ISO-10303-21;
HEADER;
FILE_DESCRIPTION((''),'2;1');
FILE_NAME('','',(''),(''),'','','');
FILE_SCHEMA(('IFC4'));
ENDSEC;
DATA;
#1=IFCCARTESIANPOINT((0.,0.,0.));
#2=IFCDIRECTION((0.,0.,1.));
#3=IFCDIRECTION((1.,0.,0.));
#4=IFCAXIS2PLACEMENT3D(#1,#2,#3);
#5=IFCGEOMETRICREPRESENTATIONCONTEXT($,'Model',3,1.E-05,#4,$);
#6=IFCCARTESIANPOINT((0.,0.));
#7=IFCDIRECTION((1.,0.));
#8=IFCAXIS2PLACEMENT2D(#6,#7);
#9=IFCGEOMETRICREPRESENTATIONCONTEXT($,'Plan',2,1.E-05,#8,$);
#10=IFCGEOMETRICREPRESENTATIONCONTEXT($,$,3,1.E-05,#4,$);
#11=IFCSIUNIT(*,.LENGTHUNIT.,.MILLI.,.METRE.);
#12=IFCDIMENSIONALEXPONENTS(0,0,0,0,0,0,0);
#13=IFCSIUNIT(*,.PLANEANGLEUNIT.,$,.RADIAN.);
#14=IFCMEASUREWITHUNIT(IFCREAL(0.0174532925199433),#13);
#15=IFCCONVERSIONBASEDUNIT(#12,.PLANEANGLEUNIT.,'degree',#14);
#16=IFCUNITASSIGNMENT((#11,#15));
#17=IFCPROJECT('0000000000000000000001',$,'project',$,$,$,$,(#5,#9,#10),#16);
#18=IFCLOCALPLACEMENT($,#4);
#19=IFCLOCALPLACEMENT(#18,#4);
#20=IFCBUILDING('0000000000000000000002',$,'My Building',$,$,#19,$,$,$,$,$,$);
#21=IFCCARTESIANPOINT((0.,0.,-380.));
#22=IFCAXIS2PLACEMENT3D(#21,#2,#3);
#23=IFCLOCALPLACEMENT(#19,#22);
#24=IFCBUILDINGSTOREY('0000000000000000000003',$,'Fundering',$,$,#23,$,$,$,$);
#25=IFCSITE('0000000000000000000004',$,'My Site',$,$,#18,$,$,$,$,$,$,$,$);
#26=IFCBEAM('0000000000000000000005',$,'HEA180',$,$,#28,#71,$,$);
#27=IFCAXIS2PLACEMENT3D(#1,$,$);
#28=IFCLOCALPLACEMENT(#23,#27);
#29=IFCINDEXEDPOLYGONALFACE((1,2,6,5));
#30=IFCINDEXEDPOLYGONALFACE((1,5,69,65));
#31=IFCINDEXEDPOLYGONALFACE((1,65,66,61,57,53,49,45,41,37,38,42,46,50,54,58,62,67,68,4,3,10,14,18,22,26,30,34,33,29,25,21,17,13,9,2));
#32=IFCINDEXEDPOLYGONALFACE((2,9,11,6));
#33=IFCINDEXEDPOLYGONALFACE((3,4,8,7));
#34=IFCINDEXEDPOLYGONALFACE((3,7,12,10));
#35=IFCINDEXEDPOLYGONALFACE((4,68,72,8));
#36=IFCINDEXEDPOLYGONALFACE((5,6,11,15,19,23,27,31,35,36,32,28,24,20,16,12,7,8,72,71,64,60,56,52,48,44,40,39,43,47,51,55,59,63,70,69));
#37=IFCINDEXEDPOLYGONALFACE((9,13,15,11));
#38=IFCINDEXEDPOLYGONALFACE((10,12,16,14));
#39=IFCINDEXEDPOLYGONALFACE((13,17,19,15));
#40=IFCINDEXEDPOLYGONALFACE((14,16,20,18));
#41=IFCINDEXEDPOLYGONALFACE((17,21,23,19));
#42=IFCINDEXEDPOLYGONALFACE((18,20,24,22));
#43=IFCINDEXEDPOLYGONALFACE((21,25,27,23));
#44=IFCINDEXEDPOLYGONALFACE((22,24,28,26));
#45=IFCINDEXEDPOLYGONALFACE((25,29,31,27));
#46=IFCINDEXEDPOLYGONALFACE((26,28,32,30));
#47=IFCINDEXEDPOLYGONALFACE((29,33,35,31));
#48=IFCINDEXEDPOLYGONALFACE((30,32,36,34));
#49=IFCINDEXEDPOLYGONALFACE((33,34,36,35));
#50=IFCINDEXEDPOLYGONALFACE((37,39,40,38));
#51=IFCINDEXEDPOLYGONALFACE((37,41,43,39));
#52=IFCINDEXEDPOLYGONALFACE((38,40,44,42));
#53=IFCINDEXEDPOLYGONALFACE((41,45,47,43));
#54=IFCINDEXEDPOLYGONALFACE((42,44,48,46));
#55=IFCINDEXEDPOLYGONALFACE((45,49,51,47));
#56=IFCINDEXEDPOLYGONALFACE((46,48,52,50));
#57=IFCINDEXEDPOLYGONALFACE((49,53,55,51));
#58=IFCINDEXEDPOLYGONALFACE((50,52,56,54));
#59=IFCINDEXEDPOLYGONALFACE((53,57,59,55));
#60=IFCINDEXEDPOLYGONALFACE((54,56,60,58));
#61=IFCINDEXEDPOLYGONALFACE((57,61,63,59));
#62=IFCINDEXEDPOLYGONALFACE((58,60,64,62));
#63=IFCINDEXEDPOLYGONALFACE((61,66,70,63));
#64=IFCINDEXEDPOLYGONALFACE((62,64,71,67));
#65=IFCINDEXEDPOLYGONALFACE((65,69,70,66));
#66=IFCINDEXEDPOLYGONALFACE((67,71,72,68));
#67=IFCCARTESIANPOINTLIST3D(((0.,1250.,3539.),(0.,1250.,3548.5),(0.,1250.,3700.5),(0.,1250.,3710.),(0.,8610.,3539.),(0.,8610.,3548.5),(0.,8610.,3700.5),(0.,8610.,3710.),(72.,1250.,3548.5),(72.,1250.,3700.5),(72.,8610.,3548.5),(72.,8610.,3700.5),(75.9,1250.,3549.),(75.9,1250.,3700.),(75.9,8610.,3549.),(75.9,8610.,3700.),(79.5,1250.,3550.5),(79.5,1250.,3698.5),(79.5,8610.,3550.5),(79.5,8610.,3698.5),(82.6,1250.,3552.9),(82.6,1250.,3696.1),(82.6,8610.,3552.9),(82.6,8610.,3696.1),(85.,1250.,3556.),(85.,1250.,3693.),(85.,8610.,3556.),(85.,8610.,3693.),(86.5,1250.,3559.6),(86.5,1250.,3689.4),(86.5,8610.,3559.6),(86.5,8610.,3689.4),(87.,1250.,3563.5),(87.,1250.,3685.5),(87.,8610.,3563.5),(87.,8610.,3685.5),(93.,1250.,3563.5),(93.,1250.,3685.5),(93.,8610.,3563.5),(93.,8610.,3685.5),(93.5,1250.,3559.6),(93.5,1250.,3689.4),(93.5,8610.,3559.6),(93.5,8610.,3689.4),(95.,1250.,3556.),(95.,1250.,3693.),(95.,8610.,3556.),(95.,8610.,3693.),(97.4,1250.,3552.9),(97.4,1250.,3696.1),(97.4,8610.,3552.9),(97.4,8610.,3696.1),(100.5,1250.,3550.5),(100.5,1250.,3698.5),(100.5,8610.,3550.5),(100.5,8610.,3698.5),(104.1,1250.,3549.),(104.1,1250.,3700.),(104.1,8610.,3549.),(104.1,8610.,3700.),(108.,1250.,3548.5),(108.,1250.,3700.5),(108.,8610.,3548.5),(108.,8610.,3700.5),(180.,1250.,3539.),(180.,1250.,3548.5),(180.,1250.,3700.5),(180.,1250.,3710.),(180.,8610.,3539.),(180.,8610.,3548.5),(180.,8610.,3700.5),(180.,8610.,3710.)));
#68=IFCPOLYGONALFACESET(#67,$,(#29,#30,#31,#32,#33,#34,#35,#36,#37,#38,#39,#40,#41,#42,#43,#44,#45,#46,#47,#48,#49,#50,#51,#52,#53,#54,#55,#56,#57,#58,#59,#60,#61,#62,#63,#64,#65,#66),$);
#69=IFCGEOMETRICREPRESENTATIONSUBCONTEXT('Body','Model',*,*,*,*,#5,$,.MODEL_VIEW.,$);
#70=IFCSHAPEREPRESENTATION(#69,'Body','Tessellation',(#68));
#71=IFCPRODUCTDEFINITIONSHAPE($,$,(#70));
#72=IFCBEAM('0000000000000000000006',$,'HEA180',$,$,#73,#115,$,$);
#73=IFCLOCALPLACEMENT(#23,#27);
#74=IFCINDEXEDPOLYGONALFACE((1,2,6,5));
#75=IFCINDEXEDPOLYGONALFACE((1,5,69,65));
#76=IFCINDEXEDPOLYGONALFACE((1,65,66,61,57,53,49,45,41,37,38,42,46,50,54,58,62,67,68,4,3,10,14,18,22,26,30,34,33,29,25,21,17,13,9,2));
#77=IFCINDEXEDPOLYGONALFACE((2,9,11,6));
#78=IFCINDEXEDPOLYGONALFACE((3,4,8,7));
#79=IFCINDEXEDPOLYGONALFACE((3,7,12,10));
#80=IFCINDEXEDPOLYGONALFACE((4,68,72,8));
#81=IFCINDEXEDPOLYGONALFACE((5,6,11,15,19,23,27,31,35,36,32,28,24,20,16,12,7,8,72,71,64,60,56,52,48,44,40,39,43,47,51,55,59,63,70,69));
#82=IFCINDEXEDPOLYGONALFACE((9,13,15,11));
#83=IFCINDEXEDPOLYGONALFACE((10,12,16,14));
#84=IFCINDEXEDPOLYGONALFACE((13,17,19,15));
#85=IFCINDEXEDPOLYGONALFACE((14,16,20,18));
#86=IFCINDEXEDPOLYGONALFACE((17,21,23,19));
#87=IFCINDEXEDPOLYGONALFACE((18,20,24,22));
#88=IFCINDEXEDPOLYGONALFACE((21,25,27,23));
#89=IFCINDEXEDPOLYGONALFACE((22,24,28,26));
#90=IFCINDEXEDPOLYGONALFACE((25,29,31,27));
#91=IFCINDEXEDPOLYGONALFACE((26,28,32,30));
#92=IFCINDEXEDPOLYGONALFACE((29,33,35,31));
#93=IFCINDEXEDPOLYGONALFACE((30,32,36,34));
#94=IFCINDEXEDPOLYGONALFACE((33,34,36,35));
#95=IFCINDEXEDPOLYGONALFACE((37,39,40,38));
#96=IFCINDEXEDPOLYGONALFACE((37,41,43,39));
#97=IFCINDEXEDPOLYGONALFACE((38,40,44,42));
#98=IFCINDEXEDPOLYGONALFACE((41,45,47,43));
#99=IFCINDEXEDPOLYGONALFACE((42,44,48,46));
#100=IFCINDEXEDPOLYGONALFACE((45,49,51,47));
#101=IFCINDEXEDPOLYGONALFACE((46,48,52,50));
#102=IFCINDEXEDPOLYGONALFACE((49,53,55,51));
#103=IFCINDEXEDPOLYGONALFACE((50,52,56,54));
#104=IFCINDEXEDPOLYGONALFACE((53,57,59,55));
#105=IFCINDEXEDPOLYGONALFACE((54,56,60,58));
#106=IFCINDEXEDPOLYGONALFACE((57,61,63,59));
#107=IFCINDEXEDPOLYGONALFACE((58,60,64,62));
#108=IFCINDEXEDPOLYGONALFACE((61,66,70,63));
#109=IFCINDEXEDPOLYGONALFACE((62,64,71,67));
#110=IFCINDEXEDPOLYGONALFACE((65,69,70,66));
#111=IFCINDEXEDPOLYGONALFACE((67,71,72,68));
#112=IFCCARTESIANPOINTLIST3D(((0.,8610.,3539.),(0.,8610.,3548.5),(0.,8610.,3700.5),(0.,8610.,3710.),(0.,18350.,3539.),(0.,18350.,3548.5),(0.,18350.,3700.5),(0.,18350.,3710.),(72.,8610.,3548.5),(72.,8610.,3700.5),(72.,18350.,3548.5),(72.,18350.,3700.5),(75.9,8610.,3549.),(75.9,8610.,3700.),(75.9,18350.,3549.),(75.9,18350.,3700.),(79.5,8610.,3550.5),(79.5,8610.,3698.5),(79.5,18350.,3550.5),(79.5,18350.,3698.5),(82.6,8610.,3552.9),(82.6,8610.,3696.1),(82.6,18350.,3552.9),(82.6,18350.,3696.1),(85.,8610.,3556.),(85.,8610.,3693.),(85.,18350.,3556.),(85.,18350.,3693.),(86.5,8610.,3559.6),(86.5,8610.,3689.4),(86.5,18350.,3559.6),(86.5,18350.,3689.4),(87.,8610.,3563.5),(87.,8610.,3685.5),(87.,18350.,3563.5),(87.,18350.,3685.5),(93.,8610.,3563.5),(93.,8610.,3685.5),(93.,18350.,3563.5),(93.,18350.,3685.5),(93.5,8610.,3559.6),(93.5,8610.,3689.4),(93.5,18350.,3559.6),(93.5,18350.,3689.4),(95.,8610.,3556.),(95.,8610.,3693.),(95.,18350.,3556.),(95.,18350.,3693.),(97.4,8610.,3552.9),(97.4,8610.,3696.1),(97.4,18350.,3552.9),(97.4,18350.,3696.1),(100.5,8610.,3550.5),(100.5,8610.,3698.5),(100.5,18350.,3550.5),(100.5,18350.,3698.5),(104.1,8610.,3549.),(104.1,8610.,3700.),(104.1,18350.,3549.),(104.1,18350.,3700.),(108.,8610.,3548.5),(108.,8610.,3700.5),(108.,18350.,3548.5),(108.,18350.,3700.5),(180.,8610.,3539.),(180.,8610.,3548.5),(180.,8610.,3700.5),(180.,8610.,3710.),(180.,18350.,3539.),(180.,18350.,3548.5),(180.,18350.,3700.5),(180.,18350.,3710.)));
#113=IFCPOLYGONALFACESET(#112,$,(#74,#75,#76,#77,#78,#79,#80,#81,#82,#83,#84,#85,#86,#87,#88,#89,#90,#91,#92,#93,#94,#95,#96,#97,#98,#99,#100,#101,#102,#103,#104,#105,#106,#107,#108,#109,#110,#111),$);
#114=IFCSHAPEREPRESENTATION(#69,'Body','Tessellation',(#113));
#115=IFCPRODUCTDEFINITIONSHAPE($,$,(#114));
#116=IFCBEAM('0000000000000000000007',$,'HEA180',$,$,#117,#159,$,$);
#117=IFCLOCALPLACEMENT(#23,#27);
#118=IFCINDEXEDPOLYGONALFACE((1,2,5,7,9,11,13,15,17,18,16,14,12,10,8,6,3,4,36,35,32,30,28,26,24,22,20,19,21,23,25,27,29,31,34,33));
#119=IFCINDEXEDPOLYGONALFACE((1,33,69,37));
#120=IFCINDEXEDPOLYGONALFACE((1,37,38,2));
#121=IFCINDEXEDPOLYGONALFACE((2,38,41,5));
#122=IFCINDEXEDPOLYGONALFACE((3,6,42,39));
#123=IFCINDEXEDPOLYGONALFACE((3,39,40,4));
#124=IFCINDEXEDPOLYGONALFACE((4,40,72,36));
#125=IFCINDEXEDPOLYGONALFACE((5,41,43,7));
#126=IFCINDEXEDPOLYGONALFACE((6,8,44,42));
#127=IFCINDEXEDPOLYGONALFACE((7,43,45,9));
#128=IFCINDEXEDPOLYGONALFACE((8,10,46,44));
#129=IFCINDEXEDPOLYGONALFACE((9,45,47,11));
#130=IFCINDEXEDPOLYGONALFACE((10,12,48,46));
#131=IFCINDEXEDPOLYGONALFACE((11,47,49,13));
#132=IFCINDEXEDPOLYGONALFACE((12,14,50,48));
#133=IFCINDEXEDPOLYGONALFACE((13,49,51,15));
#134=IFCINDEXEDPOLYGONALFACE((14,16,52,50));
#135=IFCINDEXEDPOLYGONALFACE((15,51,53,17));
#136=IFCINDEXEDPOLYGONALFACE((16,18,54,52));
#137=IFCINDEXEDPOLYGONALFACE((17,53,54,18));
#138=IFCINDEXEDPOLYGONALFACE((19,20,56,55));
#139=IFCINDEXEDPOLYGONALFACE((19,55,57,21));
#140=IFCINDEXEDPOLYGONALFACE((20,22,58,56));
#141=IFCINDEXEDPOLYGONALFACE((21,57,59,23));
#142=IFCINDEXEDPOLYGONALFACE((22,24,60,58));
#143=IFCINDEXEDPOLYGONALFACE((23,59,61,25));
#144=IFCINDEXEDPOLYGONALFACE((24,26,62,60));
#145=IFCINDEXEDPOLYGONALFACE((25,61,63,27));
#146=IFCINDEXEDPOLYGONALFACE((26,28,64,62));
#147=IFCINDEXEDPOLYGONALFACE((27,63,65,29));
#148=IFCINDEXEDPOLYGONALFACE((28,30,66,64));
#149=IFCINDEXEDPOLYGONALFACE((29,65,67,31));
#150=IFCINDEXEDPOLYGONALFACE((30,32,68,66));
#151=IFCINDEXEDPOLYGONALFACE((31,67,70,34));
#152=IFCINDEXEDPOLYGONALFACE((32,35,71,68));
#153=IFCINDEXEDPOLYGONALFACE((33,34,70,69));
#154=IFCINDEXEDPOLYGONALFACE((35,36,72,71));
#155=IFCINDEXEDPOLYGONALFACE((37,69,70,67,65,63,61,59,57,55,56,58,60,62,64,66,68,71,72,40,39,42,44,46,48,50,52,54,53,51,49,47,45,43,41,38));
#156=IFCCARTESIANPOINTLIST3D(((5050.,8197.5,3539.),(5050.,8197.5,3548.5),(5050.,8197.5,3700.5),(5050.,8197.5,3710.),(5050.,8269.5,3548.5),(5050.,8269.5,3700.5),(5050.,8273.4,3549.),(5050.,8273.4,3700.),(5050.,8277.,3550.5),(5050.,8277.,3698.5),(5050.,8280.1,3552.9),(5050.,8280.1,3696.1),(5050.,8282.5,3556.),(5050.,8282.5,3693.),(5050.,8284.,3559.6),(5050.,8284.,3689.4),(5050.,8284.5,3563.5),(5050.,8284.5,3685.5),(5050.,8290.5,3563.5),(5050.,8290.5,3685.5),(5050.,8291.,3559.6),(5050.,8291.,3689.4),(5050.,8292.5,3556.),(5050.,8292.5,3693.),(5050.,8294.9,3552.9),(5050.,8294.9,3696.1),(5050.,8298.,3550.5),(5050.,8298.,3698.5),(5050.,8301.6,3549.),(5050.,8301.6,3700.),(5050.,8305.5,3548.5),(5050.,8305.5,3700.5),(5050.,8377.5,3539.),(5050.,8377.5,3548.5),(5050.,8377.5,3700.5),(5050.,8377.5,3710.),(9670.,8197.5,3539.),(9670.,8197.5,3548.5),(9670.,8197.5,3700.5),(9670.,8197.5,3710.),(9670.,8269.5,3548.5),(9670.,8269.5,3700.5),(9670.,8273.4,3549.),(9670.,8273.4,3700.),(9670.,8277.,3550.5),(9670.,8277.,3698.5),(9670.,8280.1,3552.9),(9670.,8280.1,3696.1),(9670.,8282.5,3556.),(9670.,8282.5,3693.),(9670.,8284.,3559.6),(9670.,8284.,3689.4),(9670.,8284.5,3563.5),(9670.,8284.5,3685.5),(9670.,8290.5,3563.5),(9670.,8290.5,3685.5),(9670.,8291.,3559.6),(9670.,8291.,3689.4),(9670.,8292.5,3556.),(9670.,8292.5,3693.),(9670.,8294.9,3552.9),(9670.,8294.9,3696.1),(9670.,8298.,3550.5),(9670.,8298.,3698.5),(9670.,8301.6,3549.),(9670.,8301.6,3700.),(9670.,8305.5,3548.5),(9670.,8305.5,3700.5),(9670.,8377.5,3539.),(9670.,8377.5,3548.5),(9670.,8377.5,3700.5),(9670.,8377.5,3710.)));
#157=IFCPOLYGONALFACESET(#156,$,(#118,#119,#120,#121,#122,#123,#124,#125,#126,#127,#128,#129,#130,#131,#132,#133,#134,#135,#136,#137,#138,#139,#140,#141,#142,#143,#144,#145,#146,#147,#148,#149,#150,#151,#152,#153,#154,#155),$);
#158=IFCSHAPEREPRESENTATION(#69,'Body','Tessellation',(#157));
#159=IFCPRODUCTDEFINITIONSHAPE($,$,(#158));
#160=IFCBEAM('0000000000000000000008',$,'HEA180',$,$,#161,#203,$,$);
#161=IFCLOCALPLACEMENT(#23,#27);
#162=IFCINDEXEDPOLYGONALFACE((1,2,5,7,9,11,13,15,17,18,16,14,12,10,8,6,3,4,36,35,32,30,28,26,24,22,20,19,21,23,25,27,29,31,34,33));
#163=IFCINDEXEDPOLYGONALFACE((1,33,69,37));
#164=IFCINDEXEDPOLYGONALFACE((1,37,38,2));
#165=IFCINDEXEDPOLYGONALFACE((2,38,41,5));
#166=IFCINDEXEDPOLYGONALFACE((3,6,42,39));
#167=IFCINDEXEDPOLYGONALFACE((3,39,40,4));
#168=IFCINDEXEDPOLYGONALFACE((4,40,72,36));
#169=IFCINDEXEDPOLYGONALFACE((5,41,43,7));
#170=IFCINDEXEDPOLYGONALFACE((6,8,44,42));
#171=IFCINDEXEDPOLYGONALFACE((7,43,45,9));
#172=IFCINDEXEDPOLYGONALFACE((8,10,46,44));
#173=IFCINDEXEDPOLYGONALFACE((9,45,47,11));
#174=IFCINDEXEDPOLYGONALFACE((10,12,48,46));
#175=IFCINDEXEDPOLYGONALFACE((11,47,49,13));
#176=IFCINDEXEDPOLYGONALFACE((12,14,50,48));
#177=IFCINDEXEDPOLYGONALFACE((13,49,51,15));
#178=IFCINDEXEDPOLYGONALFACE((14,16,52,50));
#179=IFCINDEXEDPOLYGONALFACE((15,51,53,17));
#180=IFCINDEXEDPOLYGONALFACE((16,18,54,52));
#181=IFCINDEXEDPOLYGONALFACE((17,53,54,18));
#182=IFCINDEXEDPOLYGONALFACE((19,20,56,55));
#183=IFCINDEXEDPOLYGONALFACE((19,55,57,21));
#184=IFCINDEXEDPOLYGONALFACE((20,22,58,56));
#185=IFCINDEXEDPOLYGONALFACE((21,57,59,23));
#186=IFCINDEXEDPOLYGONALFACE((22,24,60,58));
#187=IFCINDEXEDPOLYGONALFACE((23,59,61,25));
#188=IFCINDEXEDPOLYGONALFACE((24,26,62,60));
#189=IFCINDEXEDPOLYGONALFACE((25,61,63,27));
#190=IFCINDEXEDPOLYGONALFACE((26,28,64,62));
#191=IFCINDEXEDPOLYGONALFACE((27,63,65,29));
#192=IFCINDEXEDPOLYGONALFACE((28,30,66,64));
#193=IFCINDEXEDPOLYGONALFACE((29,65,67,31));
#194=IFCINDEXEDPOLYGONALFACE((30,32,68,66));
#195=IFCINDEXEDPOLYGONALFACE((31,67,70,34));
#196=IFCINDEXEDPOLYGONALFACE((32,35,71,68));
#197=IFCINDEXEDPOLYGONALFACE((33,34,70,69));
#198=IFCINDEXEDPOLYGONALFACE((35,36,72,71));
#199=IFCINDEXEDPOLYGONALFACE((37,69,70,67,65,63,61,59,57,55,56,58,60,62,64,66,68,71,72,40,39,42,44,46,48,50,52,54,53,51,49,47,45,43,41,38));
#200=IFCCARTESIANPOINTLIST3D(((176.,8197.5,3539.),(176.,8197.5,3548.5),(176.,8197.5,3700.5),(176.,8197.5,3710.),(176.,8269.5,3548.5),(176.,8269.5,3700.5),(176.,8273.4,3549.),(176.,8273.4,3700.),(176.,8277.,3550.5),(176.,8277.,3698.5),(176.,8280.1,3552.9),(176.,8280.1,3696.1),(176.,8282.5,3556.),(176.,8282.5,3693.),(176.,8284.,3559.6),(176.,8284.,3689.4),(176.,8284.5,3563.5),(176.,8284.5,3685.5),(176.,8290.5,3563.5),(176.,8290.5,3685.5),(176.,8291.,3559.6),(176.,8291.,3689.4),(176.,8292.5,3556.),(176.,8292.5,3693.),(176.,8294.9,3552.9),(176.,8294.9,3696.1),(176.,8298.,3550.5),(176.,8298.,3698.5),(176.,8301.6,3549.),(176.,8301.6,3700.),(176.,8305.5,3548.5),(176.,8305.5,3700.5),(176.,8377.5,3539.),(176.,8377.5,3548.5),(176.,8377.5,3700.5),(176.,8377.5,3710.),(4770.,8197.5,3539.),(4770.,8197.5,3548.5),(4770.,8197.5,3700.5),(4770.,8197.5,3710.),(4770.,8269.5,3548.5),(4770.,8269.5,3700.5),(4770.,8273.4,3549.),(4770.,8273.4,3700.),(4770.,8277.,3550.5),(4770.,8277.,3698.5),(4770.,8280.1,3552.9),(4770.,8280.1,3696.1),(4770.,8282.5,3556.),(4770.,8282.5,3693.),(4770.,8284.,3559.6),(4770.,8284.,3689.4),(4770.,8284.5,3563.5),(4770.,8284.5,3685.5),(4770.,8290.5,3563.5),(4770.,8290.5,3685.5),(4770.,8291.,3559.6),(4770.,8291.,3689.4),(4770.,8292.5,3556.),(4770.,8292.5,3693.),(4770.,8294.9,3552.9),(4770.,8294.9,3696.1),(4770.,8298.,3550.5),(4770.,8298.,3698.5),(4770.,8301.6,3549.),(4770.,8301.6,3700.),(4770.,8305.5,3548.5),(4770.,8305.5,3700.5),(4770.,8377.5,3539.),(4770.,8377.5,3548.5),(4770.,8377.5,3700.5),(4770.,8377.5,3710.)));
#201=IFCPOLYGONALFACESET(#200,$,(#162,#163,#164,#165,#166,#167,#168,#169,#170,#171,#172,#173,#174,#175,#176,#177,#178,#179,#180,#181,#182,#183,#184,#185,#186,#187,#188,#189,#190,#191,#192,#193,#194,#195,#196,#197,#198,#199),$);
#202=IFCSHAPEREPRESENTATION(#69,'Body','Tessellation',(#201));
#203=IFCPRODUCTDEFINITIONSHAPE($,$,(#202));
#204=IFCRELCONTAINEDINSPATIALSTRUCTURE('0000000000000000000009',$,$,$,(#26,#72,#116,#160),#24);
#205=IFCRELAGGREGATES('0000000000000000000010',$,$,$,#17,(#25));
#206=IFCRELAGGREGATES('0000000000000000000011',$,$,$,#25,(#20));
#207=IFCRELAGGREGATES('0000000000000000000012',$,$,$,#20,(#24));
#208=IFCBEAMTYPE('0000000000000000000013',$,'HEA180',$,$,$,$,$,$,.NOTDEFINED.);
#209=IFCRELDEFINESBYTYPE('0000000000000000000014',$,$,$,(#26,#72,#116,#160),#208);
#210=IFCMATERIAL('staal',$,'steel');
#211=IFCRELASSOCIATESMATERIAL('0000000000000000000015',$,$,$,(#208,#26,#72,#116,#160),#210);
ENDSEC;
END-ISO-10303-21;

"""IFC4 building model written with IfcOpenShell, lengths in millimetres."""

from ifc_helpers import new_model, entity, si_unit, converted_unit, frame, origin_with_axes, origin_2d_with_axis, place, context, subcontext, project, spatial, i_section, extrude, material, material_profile, profile_set, profile_usage, type_object, element, save


model = new_model("IFC4")

# Units and contexts
model_context = context("Model", 3, precision=1e-05, world=origin_with_axes())
plan_context = context("Plan", 2, precision=1e-05, world=origin_2d_with_axis())
context_of_model = context(None, 3, precision=1e-05, world=origin_with_axes())
body_context = subcontext(model_context, "Body", "Model", "MODEL_VIEW")
ifc_project = project(units=[si_unit("LENGTHUNIT", "METRE", prefix="MILLI"), converted_unit("PLANEANGLEUNIT", "degree", entity("IfcReal", 0.0174532925199433), si_unit("PLANEANGLEUNIT", "RADIAN"), dimensions=[0, 0, 0, 0, 0, 0, 0])], contexts=[model_context, plan_context, context_of_model])

# Site, building, storey
site_placement = place(None, origin_with_axes())
site = spatial("IfcSite", under=ifc_project, at=site_placement, Name="My Site")
building_placement = place(site_placement, origin_with_axes())
building = spatial("IfcBuilding", under=site, at=building_placement, Name="My Building")
storey_placement = place(building_placement, frame((0.0, 0.0, -380.0), z_axis=(0.0, 0.0, 1.0), x_axis=(1.0, 0.0, 0.0)))
storey = spatial("IfcBuildingStorey", under=building, at=storey_placement, Name="Fundering")

# Shared definitions
ifc_material_1 = material(Name="staal", Category="steel")

# Beams
ifc_material_profile_1 = material_profile(ifc_material_1, i_section(OverallWidth=180.0, OverallDepth=171.0, WebThickness=6.0, FlangeThickness=9.5, FilletRadius=15.0))
ifc_profile_set_1 = profile_set([ifc_material_profile_1], Name="HEA180")
ifc_profile_usage_1 = profile_usage(ifc_profile_set_1, cardinal=5)
beam_type_1 = type_object("IfcBeamType", Name="HEA180", PredefinedType="NOTDEFINED", material=ifc_profile_set_1)
beam_1_placement = place(storey_placement, frame((90.0, 1250.0, 3624.5), z_axis=(0.0, 1.0, 0.0), x_axis=(-1.0, 0.0, 0.0)))
element("IfcBeam", 1, at=beam_1_placement, inside=storey, type_object=beam_type_1, material=ifc_profile_usage_1, Name="HEA180", context=body_context, shape_type="SweptSolid", body=[
    extrude(i_section(OverallWidth=180.0, OverallDepth=171.0, WebThickness=6.0, FlangeThickness=9.5, FilletRadius=15.0), origin_with_axes(), (0.0, 0.0, 1.0), 7360.0),
])
ifc_profile_usage_2 = profile_usage(ifc_profile_set_1, cardinal=5)
beam_2_placement = place(storey_placement, frame((90.0, 8610.0, 3624.5), z_axis=(0.0, 1.0, 0.0), x_axis=(-1.0, 0.0, 0.0)))
element("IfcBeam", 2, at=beam_2_placement, inside=storey, type_object=beam_type_1, material=ifc_profile_usage_2, Name="HEA180", context=body_context, shape_type="SweptSolid", body=[
    extrude(i_section(OverallWidth=180.0, OverallDepth=171.0, WebThickness=6.0, FlangeThickness=9.5, FilletRadius=15.0), origin_with_axes(), (0.0, 0.0, 1.0), 9740.0),
])
ifc_profile_usage_3 = profile_usage(ifc_profile_set_1)
beam_3_placement = place(storey_placement, frame((5050.0, 8287.5, 3624.5), z_axis=(1.0, 0.0, 0.0), x_axis=(0.0, 1.0, 0.0)))
element("IfcBeam", 3, at=beam_3_placement, inside=storey, type_object=beam_type_1, material=ifc_profile_usage_3, Name="HEA180", context=body_context, shape_type="SweptSolid", body=[
    extrude(i_section(OverallWidth=180.0, OverallDepth=171.0, WebThickness=6.0, FlangeThickness=9.5, FilletRadius=15.0), origin_with_axes(), (0.0, 0.0, 1.0), 4620.0),
])
ifc_profile_usage_4 = profile_usage(ifc_profile_set_1)
beam_4_placement = place(storey_placement, frame((176.0, 8287.5, 3624.5), z_axis=(1.0, 0.0, 0.0), x_axis=(0.0, 1.0, 0.0)))
element("IfcBeam", 4, at=beam_4_placement, inside=storey, type_object=beam_type_1, material=ifc_profile_usage_4, Name="HEA180", context=body_context, shape_type="SweptSolid", body=[
    extrude(i_section(OverallWidth=180.0, OverallDepth=171.0, WebThickness=6.0, FlangeThickness=9.5, FilletRadius=15.0), origin_with_axes(), (0.0, 0.0, 1.0), 4594.0),
])

save(model, "model.ifc")
